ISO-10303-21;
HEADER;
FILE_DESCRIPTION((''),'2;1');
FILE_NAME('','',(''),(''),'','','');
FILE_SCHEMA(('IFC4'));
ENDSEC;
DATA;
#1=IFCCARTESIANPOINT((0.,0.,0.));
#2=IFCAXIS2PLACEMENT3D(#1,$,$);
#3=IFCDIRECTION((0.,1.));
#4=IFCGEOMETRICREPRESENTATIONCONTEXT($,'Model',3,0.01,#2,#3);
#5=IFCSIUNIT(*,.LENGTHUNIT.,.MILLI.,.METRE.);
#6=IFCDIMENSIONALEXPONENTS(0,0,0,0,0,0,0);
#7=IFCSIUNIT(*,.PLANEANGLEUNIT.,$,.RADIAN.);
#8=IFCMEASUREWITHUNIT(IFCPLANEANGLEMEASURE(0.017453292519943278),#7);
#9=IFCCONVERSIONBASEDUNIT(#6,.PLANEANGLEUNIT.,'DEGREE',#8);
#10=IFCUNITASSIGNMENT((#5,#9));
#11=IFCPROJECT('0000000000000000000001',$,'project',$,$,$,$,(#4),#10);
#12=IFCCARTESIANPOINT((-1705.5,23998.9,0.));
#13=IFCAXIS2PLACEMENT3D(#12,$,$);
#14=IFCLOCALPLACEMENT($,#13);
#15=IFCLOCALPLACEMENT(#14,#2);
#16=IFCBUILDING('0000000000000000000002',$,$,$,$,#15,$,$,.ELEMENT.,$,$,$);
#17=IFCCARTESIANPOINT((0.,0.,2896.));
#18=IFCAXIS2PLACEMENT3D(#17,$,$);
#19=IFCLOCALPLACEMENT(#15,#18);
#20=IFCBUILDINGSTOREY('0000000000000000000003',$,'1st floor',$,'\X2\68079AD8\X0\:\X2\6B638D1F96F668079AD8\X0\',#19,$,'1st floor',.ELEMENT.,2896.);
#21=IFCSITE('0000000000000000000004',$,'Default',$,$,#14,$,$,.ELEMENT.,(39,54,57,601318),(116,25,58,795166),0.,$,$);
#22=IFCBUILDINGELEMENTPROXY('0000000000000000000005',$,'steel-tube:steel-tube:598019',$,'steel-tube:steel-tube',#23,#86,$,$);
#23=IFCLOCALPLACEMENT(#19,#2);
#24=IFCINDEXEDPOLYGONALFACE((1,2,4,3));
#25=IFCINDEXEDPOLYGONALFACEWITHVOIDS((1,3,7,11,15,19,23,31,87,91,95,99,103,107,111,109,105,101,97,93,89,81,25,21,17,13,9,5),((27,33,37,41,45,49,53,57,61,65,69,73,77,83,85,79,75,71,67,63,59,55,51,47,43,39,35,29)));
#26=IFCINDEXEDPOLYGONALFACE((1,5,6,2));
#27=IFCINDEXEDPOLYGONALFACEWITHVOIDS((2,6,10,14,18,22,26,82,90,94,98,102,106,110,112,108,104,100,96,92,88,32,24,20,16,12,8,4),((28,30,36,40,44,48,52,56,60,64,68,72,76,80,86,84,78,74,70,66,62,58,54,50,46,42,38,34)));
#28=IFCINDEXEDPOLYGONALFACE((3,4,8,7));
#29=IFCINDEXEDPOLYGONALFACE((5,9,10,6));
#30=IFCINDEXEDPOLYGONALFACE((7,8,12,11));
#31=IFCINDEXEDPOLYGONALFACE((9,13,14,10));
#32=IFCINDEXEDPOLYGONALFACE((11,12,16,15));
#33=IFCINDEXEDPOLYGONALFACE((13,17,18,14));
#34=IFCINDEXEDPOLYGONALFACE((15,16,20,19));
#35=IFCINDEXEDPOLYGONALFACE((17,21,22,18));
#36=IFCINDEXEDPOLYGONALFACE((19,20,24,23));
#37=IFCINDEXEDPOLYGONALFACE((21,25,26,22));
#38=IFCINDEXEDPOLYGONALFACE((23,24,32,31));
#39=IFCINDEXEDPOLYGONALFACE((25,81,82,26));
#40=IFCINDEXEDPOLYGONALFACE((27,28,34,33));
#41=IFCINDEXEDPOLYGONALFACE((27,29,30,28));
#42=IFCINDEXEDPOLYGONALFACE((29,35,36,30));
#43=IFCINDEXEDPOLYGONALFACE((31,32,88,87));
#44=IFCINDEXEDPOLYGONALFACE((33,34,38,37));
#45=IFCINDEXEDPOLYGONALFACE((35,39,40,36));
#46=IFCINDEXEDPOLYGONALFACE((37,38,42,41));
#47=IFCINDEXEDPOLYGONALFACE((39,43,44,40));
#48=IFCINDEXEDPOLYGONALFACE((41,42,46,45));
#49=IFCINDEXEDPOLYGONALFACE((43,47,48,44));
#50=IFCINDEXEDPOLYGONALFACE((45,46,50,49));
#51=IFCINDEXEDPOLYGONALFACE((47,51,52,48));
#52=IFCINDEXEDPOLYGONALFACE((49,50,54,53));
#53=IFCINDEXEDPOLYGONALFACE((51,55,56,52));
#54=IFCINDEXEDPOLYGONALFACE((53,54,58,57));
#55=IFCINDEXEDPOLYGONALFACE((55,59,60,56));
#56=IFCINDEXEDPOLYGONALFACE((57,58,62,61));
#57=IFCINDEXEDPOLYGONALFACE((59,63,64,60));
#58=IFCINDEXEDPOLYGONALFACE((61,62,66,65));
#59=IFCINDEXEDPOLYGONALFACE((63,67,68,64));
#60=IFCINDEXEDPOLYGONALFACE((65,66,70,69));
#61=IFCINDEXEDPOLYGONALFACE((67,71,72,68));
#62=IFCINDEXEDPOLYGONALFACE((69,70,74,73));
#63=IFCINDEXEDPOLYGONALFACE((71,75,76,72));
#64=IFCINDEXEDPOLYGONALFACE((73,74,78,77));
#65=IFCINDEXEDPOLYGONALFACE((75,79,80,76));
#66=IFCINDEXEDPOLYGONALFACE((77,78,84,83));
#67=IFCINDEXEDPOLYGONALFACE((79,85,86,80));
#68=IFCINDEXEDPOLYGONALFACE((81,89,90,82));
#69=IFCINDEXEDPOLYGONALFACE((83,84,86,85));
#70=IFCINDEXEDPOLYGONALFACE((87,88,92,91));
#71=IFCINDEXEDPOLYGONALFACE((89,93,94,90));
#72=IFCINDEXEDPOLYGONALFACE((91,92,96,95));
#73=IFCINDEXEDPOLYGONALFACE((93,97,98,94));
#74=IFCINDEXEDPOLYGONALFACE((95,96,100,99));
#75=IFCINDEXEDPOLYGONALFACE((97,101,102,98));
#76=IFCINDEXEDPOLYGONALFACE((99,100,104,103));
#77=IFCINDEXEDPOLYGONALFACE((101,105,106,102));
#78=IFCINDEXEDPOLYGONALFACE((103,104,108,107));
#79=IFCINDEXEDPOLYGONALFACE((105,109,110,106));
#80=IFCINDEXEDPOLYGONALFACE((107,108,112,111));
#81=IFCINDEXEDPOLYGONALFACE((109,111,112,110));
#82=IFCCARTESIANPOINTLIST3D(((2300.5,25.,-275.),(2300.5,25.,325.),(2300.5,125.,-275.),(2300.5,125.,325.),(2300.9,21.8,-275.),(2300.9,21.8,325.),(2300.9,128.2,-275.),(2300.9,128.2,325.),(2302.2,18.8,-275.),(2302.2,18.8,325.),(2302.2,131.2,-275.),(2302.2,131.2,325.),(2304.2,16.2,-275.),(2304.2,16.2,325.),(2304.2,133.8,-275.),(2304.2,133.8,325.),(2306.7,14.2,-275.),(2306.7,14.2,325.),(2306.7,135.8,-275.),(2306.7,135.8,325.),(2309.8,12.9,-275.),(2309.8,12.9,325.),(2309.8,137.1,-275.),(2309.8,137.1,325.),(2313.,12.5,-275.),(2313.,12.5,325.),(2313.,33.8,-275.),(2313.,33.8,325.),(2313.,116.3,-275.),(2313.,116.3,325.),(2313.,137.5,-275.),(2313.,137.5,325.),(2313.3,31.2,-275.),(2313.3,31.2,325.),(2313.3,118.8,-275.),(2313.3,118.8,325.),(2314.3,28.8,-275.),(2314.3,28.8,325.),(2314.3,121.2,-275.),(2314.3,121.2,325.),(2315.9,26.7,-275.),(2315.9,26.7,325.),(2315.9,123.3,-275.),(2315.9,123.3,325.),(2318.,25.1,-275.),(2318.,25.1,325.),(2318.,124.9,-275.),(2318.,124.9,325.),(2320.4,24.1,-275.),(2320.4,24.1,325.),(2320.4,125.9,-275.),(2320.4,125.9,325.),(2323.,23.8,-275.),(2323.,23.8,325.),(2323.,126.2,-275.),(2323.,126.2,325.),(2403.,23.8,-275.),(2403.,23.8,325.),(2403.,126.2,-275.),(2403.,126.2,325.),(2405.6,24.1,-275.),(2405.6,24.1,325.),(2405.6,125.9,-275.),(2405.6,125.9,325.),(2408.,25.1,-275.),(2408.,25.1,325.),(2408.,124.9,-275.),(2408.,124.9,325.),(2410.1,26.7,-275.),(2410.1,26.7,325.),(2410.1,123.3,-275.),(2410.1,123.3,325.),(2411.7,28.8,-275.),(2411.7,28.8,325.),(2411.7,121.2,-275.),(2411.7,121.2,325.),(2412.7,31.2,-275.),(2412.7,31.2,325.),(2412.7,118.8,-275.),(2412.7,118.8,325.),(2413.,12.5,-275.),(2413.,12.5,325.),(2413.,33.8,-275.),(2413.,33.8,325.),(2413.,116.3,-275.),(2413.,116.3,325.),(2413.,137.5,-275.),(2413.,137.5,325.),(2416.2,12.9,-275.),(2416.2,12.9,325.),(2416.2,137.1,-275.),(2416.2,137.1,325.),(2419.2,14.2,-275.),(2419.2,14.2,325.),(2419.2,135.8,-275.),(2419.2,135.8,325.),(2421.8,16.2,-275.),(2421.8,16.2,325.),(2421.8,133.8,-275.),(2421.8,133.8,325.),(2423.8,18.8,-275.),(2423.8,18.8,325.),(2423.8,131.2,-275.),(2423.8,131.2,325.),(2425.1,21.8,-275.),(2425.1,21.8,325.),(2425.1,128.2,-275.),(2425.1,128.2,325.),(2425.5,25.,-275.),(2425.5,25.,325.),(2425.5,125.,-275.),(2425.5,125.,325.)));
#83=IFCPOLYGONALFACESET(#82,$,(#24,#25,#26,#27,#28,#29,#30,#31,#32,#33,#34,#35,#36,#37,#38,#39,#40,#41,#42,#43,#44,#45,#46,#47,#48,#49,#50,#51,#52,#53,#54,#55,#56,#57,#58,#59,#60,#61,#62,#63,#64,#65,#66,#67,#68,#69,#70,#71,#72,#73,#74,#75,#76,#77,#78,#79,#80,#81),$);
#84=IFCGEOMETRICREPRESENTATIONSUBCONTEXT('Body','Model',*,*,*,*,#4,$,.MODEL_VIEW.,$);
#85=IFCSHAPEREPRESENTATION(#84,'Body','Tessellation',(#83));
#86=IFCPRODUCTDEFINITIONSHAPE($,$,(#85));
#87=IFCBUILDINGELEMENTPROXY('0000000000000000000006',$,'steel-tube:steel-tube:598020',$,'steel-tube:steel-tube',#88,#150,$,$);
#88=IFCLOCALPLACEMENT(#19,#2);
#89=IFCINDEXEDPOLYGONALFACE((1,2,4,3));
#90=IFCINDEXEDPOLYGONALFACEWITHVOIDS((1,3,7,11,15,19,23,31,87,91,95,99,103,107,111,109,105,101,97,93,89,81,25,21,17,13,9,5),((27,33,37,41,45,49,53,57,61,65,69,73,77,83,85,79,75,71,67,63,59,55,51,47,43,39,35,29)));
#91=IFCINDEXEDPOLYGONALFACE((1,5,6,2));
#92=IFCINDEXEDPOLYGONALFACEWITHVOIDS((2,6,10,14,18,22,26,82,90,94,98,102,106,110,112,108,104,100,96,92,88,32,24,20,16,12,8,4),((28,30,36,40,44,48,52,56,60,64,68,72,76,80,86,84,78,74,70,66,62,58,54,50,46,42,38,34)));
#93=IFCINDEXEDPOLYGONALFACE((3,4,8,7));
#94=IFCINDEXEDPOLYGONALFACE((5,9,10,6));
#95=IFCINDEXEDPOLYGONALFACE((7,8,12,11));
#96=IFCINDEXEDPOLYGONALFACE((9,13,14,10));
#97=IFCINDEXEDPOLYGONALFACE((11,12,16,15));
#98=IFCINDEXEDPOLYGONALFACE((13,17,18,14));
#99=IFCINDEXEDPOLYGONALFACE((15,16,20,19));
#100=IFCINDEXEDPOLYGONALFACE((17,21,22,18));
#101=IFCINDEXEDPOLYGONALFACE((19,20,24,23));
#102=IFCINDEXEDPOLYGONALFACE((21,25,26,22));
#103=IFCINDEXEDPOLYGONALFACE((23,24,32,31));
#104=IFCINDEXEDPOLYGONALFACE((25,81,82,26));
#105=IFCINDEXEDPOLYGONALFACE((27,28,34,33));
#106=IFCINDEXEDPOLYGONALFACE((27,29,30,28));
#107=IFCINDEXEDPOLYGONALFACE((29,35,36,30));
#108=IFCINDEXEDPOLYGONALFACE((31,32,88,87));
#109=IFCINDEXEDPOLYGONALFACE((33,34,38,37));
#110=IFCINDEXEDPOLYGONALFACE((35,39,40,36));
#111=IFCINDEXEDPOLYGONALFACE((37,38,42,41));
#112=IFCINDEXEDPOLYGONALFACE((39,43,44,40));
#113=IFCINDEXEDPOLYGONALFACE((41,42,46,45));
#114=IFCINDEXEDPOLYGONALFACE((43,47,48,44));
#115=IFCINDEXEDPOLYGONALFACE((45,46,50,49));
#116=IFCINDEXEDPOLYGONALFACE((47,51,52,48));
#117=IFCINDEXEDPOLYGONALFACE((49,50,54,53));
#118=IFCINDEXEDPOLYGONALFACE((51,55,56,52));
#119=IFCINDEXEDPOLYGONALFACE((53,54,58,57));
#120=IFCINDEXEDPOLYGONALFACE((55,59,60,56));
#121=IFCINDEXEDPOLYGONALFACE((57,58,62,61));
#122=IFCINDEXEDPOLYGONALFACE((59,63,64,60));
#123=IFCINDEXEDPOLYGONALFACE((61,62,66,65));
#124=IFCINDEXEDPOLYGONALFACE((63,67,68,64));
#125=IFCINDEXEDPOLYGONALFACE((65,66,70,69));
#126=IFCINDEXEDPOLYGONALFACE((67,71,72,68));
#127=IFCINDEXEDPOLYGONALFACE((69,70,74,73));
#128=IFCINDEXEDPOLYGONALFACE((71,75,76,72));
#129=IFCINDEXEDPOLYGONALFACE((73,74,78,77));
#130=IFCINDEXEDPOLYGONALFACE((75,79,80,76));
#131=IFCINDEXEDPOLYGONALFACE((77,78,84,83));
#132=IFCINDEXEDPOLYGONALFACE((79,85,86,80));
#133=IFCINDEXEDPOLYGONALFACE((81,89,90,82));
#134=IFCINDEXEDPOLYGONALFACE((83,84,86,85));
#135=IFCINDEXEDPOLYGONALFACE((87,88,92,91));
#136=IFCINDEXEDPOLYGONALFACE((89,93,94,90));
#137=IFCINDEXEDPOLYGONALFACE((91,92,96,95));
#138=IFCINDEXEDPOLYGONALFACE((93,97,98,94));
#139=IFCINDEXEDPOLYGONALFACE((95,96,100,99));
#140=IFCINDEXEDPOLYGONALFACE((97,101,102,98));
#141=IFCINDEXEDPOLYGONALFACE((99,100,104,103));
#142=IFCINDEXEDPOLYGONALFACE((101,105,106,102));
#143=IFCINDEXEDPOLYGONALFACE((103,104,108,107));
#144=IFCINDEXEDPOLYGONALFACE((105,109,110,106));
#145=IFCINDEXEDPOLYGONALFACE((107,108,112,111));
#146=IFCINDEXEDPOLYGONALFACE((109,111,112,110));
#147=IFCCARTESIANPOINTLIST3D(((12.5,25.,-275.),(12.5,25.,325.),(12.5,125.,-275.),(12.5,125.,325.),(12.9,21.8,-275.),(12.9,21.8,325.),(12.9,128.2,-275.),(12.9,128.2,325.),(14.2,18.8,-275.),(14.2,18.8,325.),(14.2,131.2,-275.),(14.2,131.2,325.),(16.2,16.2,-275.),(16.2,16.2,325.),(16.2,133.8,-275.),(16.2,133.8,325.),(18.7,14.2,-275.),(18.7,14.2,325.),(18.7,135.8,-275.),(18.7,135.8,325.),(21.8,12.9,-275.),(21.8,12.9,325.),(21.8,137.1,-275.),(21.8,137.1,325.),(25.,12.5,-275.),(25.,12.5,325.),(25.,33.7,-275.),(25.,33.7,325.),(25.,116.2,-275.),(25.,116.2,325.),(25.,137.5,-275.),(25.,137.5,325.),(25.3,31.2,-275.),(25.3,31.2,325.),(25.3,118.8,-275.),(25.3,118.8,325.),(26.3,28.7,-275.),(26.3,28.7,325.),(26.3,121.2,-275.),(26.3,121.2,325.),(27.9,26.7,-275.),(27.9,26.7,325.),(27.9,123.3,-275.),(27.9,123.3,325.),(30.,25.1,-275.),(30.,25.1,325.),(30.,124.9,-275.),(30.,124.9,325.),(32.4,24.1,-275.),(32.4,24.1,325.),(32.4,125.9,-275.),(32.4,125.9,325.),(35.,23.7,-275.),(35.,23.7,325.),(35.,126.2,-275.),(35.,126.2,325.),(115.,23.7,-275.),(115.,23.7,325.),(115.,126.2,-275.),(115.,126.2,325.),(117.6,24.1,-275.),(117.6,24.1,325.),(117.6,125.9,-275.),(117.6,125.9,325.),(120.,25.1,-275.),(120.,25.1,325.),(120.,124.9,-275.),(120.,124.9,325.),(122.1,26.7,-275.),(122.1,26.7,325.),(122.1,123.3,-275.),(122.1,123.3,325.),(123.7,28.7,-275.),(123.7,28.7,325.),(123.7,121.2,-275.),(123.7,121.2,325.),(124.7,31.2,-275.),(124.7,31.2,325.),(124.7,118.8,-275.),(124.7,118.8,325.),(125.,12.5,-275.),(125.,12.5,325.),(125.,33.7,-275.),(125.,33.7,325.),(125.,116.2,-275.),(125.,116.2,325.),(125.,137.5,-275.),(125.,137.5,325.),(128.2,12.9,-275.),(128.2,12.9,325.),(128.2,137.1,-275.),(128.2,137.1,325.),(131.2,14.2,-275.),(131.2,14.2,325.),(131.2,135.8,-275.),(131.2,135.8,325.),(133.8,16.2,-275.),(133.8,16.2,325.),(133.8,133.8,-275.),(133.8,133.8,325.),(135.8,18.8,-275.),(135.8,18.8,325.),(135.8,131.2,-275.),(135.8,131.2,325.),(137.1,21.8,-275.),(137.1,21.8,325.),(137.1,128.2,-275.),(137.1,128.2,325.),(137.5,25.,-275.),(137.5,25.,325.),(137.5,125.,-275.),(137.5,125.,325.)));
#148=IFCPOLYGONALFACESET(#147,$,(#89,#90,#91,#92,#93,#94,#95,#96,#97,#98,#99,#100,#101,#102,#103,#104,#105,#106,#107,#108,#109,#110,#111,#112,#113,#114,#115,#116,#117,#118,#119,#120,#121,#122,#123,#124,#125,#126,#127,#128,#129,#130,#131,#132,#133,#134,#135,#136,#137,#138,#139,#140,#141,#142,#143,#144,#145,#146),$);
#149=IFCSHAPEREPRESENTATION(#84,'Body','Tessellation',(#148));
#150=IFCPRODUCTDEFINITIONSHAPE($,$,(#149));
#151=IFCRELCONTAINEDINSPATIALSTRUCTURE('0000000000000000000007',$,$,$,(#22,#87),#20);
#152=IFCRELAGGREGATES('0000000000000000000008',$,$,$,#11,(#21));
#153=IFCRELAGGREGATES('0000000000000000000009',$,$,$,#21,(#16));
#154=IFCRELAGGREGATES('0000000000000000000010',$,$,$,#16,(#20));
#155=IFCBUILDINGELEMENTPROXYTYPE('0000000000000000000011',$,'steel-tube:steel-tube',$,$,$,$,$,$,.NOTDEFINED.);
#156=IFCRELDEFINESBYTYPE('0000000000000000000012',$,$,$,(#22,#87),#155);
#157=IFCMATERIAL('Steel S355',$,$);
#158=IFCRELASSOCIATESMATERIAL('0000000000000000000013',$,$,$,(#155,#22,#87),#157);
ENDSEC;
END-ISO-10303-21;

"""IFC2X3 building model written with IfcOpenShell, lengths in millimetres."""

from ifc_helpers import new_model, entity, si_unit, converted_unit, direction, frame, frame_2d, origin, place, context, subcontext, project, spatial, polyline, circle_curve, parameter, trimmed, segment, composite_curve, outline, extrude, source, transform, mapped, material, type_object, type_shapes, element, save


model = new_model("IFC2X3")

# Units and contexts
model_context = context("Model", 3, precision=0.01, world=origin(), true_north=direction((0.0, 1.0)))
body_context = subcontext(model_context, "Body", "Model", "MODEL_VIEW")
ifc_project = project(units=[si_unit("LENGTHUNIT", "METRE", prefix="MILLI"), converted_unit("PLANEANGLEUNIT", "DEGREE", entity("IfcPlaneAngleMeasure", 0.017453292519943278), si_unit("PLANEANGLEUNIT", "RADIAN"), dimensions=[0, 0, 0, 0, 0, 0, 0])], contexts=[model_context])

# Site, building, storey
site_placement = place(None, frame((-1705.5, 23998.9, 0.0)))
site = spatial("IfcSite", under=ifc_project, at=site_placement, Name="Default", CompositionType="ELEMENT", RefLatitude=(39, 54, 57, 601318), RefLongitude=(116, 25, 58, 795166), RefElevation=0.0)
building_placement = place(site_placement, origin())
building = spatial("IfcBuilding", under=site, at=building_placement, CompositionType="ELEMENT")
storey_placement = place(building_placement, frame((0.0, 0.0, 2896.0)))
storey = spatial("IfcBuildingStorey", under=building, at=storey_placement, Name="1st floor", ObjectType="标高:正负零标高", LongName="1st floor", CompositionType="ELEMENT", Elevation=2896.0)

# Shared definitions
ifc_material_1 = material(Name="Steel S355")

# Building element proxies
building_element_proxy_type_1 = type_object("IfcBuildingElementProxyType", Name="steel-tube:steel-tube", PredefinedType="NOTDEFINED", material=ifc_material_1)
shared_shape_1 = source(origin(), body_context, "Body", "SweptSolid", [
    extrude(outline(composite_curve([segment(trimmed(circle_curve(frame_2d((50.0, -50.0), x_axis=(1.0, 0.0)), 12.5), [parameter(270.0)], [parameter(0.0)], True, "PARAMETER"), True, "CONTINUOUS"), segment(polyline([(62.5, -50.0), (62.5, 50.0)]), True, "CONTINUOUS"), segment(trimmed(circle_curve(frame_2d((50.0, 50.0), x_axis=(1.0, 0.0)), 12.5), [parameter(0.0)], [parameter(90.0)], True, "PARAMETER"), True, "CONTINUOUS"), segment(polyline([(50.0, 62.5), (-50.0, 62.5)]), True, "CONTINUOUS"), segment(trimmed(circle_curve(frame_2d((-50.0, 50.0), x_axis=(1.0, 0.0)), 12.5), [parameter(90.0)], [parameter(180.0)], True, "PARAMETER"), True, "CONTINUOUS"), segment(polyline([(-62.5, 50.0), (-62.5, -50.0)]), True, "CONTINUOUS"), segment(trimmed(circle_curve(frame_2d((-50.0, -50.0), x_axis=(1.0, 0.0)), 12.5), [parameter(180.0)], [parameter(270.0)], True, "PARAMETER"), True, "CONTINUOUS"), segment(polyline([(-50.0, -62.5), (50.0, -62.5)]), True, "CONTINUOUS")], self_intersect=False), holes=[composite_curve([segment(trimmed(circle_curve(frame_2d((-41.2, 40.0), x_axis=(1.0, 0.0)), 10.0), [parameter(90.0)], [parameter(180.0)], True, "PARAMETER"), False, "CONTINUOUS"), segment(polyline([(-41.3, 50.0), (41.2, 50.0)]), True, "CONTINUOUS"), segment(trimmed(circle_curve(frame_2d((41.2, 40.0), x_axis=(1.0, 0.0)), 10.0), [parameter(0.0)], [parameter(90.0)], True, "PARAMETER"), False, "CONTINUOUS"), segment(polyline([(51.2, 40.0), (51.2, -40.0)]), True, "CONTINUOUS"), segment(trimmed(circle_curve(frame_2d((41.2, -40.0), x_axis=(1.0, 0.0)), 10.0), [parameter(270.0)], [parameter(360.0)], True, "PARAMETER"), False, "CONTINUOUS"), segment(polyline([(41.2, -50.0), (-41.3, -50.0)]), True, "CONTINUOUS"), segment(trimmed(circle_curve(frame_2d((-41.3, -40.0), x_axis=(1.0, 0.0)), 10.0), [parameter(180.0)], [parameter(270.0)], True, "PARAMETER"), False, "CONTINUOUS"), segment(polyline([(-51.3, -40.0), (-51.3, 40.0)]), True, "CONTINUOUS")], self_intersect=False)]), frame((62.5, 62.5, -175.0)), (0.0, 0.0, 1.0), 600.0),
])
type_shapes(building_element_proxy_type_1, [shared_shape_1])
for number, where, z_axis, x_axis, name in (
    (1, (2300.5, 137.5, -100.0), (0.0, 0.0, 1.0), (0.0, -1.0, 0.0), "steel-tube:steel-tube:598019"),
    (2, (12.5, 137.5, -100.0), (0.0, 0.0, 1.0), (0.0, -1.0, 0.0), "steel-tube:steel-tube:598020"),
):
    element("IfcBuildingElementProxy", number, at=place(storey_placement, frame(where, z_axis=z_axis, x_axis=x_axis)), inside=storey, type_object=building_element_proxy_type_1, material=ifc_material_1, Name=name, ObjectType="steel-tube:steel-tube", context=body_context, shape_type="MappedRepresentation", body=[
        mapped(shared_shape_1, transform((0.0, 0.0, 0.0), scale=1.0)),
    ])

save(model, "model.ifc")
